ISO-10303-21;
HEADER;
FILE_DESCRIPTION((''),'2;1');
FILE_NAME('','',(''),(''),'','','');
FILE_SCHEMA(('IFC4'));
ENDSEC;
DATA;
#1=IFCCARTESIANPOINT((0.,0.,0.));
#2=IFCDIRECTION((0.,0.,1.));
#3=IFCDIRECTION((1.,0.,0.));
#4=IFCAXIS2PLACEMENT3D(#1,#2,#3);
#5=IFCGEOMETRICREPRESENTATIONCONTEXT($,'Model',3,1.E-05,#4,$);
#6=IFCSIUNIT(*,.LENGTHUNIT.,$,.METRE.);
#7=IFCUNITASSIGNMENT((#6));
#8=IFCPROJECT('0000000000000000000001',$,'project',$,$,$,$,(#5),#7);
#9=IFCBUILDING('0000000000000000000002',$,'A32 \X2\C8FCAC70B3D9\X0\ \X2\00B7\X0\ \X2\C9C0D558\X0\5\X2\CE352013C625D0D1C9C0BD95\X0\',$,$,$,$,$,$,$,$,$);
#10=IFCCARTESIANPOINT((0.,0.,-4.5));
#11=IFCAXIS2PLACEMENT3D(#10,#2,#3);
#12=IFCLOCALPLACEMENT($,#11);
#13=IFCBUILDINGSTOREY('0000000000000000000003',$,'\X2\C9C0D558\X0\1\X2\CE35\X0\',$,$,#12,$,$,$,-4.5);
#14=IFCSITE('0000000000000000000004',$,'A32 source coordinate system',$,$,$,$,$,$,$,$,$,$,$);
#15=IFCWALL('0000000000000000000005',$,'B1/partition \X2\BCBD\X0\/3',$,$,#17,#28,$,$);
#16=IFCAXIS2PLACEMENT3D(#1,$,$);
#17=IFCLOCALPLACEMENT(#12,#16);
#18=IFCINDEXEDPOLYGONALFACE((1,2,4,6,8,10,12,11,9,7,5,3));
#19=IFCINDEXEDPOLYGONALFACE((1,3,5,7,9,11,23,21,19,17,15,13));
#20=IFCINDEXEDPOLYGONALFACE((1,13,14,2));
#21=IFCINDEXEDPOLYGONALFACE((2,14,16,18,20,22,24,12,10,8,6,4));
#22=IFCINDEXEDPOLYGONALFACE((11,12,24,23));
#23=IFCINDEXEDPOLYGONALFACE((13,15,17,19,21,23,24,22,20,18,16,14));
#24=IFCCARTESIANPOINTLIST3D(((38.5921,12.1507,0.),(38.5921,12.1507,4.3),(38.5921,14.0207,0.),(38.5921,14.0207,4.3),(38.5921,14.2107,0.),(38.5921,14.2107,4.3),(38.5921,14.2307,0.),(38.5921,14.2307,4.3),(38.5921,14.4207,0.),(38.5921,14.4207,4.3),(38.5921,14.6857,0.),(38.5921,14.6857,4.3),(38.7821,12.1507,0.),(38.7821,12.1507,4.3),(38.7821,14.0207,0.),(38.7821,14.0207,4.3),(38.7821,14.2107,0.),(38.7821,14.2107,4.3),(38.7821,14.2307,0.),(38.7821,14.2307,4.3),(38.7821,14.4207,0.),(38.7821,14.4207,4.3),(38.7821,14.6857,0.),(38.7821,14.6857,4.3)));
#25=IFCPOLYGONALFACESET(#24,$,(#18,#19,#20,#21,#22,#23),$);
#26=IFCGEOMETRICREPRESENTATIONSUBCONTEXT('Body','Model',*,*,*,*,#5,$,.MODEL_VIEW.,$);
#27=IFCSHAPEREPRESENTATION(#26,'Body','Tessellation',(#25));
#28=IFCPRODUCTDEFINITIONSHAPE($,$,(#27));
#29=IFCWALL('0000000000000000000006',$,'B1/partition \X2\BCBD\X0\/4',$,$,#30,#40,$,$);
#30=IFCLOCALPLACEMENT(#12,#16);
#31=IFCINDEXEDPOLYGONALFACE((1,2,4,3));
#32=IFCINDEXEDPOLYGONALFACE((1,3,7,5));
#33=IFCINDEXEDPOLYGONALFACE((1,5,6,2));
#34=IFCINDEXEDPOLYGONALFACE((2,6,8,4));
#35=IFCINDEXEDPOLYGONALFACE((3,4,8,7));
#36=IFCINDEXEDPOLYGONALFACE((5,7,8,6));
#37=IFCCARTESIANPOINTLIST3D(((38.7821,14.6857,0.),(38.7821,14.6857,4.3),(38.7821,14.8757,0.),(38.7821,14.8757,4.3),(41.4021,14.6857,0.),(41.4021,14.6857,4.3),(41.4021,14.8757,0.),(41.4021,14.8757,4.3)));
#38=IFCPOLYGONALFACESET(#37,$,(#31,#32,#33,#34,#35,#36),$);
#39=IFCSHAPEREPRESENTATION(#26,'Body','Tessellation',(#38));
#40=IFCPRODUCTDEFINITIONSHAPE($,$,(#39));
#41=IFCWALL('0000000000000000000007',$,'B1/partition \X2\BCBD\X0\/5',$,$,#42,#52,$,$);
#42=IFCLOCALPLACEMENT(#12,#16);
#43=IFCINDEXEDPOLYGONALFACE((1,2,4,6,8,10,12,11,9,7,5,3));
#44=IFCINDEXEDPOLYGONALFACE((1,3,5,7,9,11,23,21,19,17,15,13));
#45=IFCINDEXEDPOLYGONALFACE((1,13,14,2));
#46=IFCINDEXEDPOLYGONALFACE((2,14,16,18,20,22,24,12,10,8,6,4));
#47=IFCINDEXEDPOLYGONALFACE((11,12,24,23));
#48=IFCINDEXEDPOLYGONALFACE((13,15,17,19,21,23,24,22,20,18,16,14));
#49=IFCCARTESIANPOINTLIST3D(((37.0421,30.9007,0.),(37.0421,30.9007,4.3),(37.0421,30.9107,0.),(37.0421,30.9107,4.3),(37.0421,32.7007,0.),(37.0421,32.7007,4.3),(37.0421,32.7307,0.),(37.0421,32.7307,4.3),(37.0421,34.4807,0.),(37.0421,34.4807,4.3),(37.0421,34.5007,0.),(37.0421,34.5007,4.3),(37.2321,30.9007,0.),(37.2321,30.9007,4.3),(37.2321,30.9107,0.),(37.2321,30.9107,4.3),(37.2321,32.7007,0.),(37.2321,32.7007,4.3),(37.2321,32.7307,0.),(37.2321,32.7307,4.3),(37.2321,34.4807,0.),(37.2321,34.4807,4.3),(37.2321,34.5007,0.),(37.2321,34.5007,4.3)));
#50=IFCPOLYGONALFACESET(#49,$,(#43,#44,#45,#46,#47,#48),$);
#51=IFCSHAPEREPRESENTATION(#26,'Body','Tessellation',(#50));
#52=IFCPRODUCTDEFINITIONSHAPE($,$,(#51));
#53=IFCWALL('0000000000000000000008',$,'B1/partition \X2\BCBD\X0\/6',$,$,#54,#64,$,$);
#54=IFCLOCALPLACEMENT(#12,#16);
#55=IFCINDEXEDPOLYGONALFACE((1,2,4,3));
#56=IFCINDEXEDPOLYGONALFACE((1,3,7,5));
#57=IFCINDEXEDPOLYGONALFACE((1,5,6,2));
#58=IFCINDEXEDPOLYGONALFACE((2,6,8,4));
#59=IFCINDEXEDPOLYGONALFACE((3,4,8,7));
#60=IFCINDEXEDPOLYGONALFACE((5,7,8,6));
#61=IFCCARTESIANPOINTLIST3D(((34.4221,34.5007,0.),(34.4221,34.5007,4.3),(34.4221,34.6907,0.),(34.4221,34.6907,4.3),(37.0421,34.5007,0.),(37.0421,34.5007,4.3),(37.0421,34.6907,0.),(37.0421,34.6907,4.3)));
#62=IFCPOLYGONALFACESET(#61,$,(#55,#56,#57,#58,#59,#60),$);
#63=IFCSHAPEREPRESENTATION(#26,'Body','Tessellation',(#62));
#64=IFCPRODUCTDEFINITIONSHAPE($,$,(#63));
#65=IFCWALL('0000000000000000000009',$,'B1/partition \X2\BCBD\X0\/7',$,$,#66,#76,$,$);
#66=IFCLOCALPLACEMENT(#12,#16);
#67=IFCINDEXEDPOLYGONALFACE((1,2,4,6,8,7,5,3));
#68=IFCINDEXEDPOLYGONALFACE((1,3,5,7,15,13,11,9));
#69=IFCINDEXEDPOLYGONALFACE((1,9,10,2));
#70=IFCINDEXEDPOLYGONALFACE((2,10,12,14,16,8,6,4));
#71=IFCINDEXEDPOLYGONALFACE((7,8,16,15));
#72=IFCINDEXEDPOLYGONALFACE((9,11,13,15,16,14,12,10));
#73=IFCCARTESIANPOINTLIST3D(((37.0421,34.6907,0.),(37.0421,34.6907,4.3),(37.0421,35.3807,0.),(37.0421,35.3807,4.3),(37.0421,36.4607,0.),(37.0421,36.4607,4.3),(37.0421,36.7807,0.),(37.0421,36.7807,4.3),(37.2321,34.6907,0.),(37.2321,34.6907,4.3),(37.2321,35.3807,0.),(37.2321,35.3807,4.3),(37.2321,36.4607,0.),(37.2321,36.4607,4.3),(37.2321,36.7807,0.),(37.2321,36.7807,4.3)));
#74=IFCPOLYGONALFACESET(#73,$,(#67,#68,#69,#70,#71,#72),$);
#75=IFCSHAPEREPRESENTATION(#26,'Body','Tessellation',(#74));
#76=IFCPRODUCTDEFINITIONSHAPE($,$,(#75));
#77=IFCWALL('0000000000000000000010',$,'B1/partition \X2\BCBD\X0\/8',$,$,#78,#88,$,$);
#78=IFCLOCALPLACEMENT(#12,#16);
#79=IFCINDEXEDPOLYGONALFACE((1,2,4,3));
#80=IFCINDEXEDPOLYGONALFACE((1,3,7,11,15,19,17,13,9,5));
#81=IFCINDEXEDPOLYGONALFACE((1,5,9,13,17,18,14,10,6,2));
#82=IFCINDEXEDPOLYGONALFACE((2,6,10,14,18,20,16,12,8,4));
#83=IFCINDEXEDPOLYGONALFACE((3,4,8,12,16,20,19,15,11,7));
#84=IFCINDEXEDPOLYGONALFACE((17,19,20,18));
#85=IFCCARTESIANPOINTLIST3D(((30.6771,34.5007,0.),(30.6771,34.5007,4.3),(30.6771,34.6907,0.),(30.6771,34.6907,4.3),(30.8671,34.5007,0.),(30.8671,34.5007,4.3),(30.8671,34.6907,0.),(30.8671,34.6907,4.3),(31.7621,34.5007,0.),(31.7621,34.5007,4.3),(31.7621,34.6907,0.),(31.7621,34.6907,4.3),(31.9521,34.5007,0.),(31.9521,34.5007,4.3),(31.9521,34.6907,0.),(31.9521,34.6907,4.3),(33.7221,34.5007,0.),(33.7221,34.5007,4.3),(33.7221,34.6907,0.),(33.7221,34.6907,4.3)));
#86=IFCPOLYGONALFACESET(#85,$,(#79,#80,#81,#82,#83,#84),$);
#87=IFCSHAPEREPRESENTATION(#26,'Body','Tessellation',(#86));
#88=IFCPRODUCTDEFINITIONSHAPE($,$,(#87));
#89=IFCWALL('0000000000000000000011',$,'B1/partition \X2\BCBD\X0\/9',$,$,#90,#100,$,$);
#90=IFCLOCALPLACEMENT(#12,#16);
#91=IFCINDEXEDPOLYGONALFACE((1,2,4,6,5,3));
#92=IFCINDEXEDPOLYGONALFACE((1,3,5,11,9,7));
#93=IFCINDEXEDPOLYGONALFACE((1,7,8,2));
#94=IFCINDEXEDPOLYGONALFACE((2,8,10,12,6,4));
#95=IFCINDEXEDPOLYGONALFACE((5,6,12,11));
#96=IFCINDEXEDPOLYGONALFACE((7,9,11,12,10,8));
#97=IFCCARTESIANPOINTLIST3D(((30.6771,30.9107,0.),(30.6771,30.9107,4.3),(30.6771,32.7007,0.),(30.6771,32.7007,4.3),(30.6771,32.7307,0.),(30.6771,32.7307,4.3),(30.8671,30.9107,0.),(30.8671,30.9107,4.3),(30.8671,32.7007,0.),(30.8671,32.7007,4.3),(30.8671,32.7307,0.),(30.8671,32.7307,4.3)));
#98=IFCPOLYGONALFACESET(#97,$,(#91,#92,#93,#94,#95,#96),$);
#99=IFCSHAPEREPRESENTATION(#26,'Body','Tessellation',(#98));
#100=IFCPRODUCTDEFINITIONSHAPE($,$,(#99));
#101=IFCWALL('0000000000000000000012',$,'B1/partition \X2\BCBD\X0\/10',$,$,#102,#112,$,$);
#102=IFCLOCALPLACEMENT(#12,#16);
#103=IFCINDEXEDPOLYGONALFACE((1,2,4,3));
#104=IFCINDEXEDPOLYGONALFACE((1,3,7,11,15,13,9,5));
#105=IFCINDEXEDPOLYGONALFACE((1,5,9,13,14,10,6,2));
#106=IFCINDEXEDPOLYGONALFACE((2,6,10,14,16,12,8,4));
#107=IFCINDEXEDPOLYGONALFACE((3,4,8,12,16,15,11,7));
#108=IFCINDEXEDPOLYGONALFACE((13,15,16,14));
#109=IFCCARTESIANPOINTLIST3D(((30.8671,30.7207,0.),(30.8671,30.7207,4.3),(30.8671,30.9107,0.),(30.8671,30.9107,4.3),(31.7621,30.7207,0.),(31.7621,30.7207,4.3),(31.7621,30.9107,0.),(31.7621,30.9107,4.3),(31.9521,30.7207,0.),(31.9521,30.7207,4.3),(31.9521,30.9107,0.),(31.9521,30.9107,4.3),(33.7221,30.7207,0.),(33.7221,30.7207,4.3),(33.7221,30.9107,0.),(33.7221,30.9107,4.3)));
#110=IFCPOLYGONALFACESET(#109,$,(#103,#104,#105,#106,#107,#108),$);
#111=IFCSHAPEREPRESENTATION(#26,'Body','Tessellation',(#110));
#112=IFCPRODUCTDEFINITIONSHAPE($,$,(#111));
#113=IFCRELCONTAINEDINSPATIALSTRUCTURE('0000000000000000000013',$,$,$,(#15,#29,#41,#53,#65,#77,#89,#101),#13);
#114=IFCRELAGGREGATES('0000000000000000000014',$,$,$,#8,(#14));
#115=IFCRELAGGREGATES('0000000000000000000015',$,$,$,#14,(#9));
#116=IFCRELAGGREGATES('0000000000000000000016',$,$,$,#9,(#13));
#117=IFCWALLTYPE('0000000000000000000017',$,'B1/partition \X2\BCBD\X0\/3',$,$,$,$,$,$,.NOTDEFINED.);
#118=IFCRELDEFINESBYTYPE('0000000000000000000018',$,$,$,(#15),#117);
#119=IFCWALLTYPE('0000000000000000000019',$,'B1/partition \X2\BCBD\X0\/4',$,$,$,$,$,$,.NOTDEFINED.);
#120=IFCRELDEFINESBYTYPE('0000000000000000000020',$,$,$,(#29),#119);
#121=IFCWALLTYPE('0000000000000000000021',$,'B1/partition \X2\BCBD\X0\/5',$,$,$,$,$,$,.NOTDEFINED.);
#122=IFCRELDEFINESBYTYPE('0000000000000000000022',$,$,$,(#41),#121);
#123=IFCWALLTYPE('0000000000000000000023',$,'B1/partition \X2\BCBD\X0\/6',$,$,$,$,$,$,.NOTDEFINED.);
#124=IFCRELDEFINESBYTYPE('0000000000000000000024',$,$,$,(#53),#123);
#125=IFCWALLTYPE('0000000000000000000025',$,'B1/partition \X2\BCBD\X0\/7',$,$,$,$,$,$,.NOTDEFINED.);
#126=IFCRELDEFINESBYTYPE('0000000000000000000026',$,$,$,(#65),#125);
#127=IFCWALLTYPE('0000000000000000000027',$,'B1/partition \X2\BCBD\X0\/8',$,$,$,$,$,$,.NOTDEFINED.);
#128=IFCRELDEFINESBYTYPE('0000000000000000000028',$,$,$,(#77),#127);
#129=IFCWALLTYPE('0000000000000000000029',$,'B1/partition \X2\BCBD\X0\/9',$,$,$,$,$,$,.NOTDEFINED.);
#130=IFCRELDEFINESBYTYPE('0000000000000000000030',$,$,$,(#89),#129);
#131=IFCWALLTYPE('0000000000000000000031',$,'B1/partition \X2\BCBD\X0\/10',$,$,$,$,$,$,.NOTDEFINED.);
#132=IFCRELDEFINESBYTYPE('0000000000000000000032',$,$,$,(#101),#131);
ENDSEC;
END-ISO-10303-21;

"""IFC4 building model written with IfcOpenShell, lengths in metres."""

from ifc_helpers import new_model, si_unit, frame, origin, origin_with_axes, place, context, subcontext, project, spatial, polyline, outline, extrude, source, transform, mapped, type_object, type_shapes, element, save


model = new_model("IFC4")

# Units and contexts
model_context = context("Model", 3, precision=1e-05, world=origin_with_axes())
body_context = subcontext(model_context, "Body", "Model", "MODEL_VIEW")
ifc_project = project(units=[si_unit("LENGTHUNIT", "METRE")], contexts=[model_context])

# Site, building, storey
site = spatial("IfcSite", under=ifc_project, Name="A32 source coordinate system")
building = spatial("IfcBuilding", under=site, Name="A32 주거동 · 지하5층–옥탑지붕")
storey_placement = place(None, frame((0.0, 0.0, -4.5), z_axis=(0.0, 0.0, 1.0), x_axis=(1.0, 0.0, 0.0)))
storey = spatial("IfcBuildingStorey", under=building, at=storey_placement, Name="지하1층", Elevation=-4.5)

# Walls
wall_type_1 = type_object("IfcWallType", Name="B1/partition 벽/3", PredefinedType="NOTDEFINED")
shared_shape_1 = source(origin(), body_context, "Body", "SweptSolid", [
    extrude(outline(polyline([(38.5921, 14.4207), (38.5921, 14.6857), (38.7821, 14.6857), (38.7821, 14.4207), (38.7821, 14.2307), (38.7821, 14.2107), (38.7821, 14.0207), (38.7821, 12.1507), (38.5921, 12.1507), (38.5921, 14.0207), (38.5921, 14.2107), (38.5921, 14.2307), (38.5921, 14.4207)])), origin(), (0.0, 0.0, 1.0), 4.3),
])
type_shapes(wall_type_1, [shared_shape_1])
wall_1_placement = place(storey_placement, origin_with_axes())
element("IfcWall", 1, at=wall_1_placement, inside=storey, type_object=wall_type_1, Name="B1/partition 벽/3", context=body_context, shape_type="MappedRepresentation", body=[
    mapped(shared_shape_1, transform((0.0, 0.0, 0.0), scale=1.0)),
])
wall_type_2 = type_object("IfcWallType", Name="B1/partition 벽/4", PredefinedType="NOTDEFINED")
shared_shape_2 = source(origin(), body_context, "Body", "SweptSolid", [
    extrude(outline(polyline([(38.7821, 14.8757), (41.4021, 14.8757), (41.4021, 14.6857), (38.7821, 14.6857), (38.7821, 14.8757)])), origin(), (0.0, 0.0, 1.0), 4.3),
])
type_shapes(wall_type_2, [shared_shape_2])
wall_2_placement = place(storey_placement, origin_with_axes())
element("IfcWall", 2, at=wall_2_placement, inside=storey, type_object=wall_type_2, Name="B1/partition 벽/4", context=body_context, shape_type="MappedRepresentation", body=[
    mapped(shared_shape_2, transform((0.0, 0.0, 0.0), scale=1.0)),
])
wall_type_3 = type_object("IfcWallType", Name="B1/partition 벽/5", PredefinedType="NOTDEFINED")
shared_shape_3 = source(origin(), body_context, "Body", "SweptSolid", [
    extrude(outline(polyline([(37.0421, 32.7307), (37.0421, 34.4807), (37.0421, 34.5007), (37.2321, 34.5007), (37.2321, 34.4807), (37.2321, 32.7307), (37.2321, 32.7007), (37.2321, 30.9107), (37.2321, 30.9007), (37.0421, 30.9007), (37.0421, 30.9107), (37.0421, 32.7007), (37.0421, 32.7307)])), origin(), (0.0, 0.0, 1.0), 4.3),
])
type_shapes(wall_type_3, [shared_shape_3])
wall_3_placement = place(storey_placement, origin_with_axes())
element("IfcWall", 3, at=wall_3_placement, inside=storey, type_object=wall_type_3, Name="B1/partition 벽/5", context=body_context, shape_type="MappedRepresentation", body=[
    mapped(shared_shape_3, transform((0.0, 0.0, 0.0), scale=1.0)),
])
wall_type_4 = type_object("IfcWallType", Name="B1/partition 벽/6", PredefinedType="NOTDEFINED")
shared_shape_4 = source(origin(), body_context, "Body", "SweptSolid", [
    extrude(outline(polyline([(34.4221, 34.5007), (34.4221, 34.6907), (37.0421, 34.6907), (37.0421, 34.5007), (34.4221, 34.5007)])), origin(), (0.0, 0.0, 1.0), 4.3),
])
type_shapes(wall_type_4, [shared_shape_4])
wall_4_placement = place(storey_placement, origin_with_axes())
element("IfcWall", 4, at=wall_4_placement, inside=storey, type_object=wall_type_4, Name="B1/partition 벽/6", context=body_context, shape_type="MappedRepresentation", body=[
    mapped(shared_shape_4, transform((0.0, 0.0, 0.0), scale=1.0)),
])
wall_type_5 = type_object("IfcWallType", Name="B1/partition 벽/7", PredefinedType="NOTDEFINED")
shared_shape_5 = source(origin(), body_context, "Body", "SweptSolid", [
    extrude(outline(polyline([(37.0421, 35.3807), (37.0421, 36.4607), (37.0421, 36.7807), (37.2321, 36.7807), (37.2321, 36.4607), (37.2321, 35.3807), (37.2321, 34.6907), (37.0421, 34.6907), (37.0421, 35.3807)])), origin(), (0.0, 0.0, 1.0), 4.3),
])
type_shapes(wall_type_5, [shared_shape_5])
wall_5_placement = place(storey_placement, origin_with_axes())
element("IfcWall", 5, at=wall_5_placement, inside=storey, type_object=wall_type_5, Name="B1/partition 벽/7", context=body_context, shape_type="MappedRepresentation", body=[
    mapped(shared_shape_5, transform((0.0, 0.0, 0.0), scale=1.0)),
])
wall_type_6 = type_object("IfcWallType", Name="B1/partition 벽/8", PredefinedType="NOTDEFINED")
shared_shape_6 = source(origin(), body_context, "Body", "SweptSolid", [
    extrude(outline(polyline([(31.9521, 34.5007), (31.7621, 34.5007), (30.8671, 34.5007), (30.6771, 34.5007), (30.6771, 34.6907), (30.8671, 34.6907), (31.7621, 34.6907), (31.9521, 34.6907), (33.7221, 34.6907), (33.7221, 34.5007), (31.9521, 34.5007)])), origin(), (0.0, 0.0, 1.0), 4.3),
])
type_shapes(wall_type_6, [shared_shape_6])
wall_6_placement = place(storey_placement, origin_with_axes())
element("IfcWall", 6, at=wall_6_placement, inside=storey, type_object=wall_type_6, Name="B1/partition 벽/8", context=body_context, shape_type="MappedRepresentation", body=[
    mapped(shared_shape_6, transform((0.0, 0.0, 0.0), scale=1.0)),
])
wall_type_7 = type_object("IfcWallType", Name="B1/partition 벽/9", PredefinedType="NOTDEFINED")
shared_shape_7 = source(origin(), body_context, "Body", "SweptSolid", [
    extrude(outline(polyline([(30.8671, 32.7307), (30.8671, 32.7007), (30.8671, 30.9107), (30.6771, 30.9107), (30.6771, 32.7007), (30.6771, 32.7307), (30.8671, 32.7307)])), origin(), (0.0, 0.0, 1.0), 4.3),
])
type_shapes(wall_type_7, [shared_shape_7])
wall_7_placement = place(storey_placement, origin_with_axes())
element("IfcWall", 7, at=wall_7_placement, inside=storey, type_object=wall_type_7, Name="B1/partition 벽/9", context=body_context, shape_type="MappedRepresentation", body=[
    mapped(shared_shape_7, transform((0.0, 0.0, 0.0), scale=1.0)),
])
wall_type_8 = type_object("IfcWallType", Name="B1/partition 벽/10", PredefinedType="NOTDEFINED")
shared_shape_8 = source(origin(), body_context, "Body", "SweptSolid", [
    extrude(outline(polyline([(31.7621, 30.9107), (31.9521, 30.9107), (33.7221, 30.9107), (33.7221, 30.7207), (31.9521, 30.7207), (31.7621, 30.7207), (30.8671, 30.7207), (30.8671, 30.9107), (31.7621, 30.9107)])), origin(), (0.0, 0.0, 1.0), 4.3),
])
type_shapes(wall_type_8, [shared_shape_8])
wall_8_placement = place(storey_placement, origin_with_axes())
element("IfcWall", 8, at=wall_8_placement, inside=storey, type_object=wall_type_8, Name="B1/partition 벽/10", context=body_context, shape_type="MappedRepresentation", body=[
    mapped(shared_shape_8, transform((0.0, 0.0, 0.0), scale=1.0)),
])

save(model, "model.ifc")
